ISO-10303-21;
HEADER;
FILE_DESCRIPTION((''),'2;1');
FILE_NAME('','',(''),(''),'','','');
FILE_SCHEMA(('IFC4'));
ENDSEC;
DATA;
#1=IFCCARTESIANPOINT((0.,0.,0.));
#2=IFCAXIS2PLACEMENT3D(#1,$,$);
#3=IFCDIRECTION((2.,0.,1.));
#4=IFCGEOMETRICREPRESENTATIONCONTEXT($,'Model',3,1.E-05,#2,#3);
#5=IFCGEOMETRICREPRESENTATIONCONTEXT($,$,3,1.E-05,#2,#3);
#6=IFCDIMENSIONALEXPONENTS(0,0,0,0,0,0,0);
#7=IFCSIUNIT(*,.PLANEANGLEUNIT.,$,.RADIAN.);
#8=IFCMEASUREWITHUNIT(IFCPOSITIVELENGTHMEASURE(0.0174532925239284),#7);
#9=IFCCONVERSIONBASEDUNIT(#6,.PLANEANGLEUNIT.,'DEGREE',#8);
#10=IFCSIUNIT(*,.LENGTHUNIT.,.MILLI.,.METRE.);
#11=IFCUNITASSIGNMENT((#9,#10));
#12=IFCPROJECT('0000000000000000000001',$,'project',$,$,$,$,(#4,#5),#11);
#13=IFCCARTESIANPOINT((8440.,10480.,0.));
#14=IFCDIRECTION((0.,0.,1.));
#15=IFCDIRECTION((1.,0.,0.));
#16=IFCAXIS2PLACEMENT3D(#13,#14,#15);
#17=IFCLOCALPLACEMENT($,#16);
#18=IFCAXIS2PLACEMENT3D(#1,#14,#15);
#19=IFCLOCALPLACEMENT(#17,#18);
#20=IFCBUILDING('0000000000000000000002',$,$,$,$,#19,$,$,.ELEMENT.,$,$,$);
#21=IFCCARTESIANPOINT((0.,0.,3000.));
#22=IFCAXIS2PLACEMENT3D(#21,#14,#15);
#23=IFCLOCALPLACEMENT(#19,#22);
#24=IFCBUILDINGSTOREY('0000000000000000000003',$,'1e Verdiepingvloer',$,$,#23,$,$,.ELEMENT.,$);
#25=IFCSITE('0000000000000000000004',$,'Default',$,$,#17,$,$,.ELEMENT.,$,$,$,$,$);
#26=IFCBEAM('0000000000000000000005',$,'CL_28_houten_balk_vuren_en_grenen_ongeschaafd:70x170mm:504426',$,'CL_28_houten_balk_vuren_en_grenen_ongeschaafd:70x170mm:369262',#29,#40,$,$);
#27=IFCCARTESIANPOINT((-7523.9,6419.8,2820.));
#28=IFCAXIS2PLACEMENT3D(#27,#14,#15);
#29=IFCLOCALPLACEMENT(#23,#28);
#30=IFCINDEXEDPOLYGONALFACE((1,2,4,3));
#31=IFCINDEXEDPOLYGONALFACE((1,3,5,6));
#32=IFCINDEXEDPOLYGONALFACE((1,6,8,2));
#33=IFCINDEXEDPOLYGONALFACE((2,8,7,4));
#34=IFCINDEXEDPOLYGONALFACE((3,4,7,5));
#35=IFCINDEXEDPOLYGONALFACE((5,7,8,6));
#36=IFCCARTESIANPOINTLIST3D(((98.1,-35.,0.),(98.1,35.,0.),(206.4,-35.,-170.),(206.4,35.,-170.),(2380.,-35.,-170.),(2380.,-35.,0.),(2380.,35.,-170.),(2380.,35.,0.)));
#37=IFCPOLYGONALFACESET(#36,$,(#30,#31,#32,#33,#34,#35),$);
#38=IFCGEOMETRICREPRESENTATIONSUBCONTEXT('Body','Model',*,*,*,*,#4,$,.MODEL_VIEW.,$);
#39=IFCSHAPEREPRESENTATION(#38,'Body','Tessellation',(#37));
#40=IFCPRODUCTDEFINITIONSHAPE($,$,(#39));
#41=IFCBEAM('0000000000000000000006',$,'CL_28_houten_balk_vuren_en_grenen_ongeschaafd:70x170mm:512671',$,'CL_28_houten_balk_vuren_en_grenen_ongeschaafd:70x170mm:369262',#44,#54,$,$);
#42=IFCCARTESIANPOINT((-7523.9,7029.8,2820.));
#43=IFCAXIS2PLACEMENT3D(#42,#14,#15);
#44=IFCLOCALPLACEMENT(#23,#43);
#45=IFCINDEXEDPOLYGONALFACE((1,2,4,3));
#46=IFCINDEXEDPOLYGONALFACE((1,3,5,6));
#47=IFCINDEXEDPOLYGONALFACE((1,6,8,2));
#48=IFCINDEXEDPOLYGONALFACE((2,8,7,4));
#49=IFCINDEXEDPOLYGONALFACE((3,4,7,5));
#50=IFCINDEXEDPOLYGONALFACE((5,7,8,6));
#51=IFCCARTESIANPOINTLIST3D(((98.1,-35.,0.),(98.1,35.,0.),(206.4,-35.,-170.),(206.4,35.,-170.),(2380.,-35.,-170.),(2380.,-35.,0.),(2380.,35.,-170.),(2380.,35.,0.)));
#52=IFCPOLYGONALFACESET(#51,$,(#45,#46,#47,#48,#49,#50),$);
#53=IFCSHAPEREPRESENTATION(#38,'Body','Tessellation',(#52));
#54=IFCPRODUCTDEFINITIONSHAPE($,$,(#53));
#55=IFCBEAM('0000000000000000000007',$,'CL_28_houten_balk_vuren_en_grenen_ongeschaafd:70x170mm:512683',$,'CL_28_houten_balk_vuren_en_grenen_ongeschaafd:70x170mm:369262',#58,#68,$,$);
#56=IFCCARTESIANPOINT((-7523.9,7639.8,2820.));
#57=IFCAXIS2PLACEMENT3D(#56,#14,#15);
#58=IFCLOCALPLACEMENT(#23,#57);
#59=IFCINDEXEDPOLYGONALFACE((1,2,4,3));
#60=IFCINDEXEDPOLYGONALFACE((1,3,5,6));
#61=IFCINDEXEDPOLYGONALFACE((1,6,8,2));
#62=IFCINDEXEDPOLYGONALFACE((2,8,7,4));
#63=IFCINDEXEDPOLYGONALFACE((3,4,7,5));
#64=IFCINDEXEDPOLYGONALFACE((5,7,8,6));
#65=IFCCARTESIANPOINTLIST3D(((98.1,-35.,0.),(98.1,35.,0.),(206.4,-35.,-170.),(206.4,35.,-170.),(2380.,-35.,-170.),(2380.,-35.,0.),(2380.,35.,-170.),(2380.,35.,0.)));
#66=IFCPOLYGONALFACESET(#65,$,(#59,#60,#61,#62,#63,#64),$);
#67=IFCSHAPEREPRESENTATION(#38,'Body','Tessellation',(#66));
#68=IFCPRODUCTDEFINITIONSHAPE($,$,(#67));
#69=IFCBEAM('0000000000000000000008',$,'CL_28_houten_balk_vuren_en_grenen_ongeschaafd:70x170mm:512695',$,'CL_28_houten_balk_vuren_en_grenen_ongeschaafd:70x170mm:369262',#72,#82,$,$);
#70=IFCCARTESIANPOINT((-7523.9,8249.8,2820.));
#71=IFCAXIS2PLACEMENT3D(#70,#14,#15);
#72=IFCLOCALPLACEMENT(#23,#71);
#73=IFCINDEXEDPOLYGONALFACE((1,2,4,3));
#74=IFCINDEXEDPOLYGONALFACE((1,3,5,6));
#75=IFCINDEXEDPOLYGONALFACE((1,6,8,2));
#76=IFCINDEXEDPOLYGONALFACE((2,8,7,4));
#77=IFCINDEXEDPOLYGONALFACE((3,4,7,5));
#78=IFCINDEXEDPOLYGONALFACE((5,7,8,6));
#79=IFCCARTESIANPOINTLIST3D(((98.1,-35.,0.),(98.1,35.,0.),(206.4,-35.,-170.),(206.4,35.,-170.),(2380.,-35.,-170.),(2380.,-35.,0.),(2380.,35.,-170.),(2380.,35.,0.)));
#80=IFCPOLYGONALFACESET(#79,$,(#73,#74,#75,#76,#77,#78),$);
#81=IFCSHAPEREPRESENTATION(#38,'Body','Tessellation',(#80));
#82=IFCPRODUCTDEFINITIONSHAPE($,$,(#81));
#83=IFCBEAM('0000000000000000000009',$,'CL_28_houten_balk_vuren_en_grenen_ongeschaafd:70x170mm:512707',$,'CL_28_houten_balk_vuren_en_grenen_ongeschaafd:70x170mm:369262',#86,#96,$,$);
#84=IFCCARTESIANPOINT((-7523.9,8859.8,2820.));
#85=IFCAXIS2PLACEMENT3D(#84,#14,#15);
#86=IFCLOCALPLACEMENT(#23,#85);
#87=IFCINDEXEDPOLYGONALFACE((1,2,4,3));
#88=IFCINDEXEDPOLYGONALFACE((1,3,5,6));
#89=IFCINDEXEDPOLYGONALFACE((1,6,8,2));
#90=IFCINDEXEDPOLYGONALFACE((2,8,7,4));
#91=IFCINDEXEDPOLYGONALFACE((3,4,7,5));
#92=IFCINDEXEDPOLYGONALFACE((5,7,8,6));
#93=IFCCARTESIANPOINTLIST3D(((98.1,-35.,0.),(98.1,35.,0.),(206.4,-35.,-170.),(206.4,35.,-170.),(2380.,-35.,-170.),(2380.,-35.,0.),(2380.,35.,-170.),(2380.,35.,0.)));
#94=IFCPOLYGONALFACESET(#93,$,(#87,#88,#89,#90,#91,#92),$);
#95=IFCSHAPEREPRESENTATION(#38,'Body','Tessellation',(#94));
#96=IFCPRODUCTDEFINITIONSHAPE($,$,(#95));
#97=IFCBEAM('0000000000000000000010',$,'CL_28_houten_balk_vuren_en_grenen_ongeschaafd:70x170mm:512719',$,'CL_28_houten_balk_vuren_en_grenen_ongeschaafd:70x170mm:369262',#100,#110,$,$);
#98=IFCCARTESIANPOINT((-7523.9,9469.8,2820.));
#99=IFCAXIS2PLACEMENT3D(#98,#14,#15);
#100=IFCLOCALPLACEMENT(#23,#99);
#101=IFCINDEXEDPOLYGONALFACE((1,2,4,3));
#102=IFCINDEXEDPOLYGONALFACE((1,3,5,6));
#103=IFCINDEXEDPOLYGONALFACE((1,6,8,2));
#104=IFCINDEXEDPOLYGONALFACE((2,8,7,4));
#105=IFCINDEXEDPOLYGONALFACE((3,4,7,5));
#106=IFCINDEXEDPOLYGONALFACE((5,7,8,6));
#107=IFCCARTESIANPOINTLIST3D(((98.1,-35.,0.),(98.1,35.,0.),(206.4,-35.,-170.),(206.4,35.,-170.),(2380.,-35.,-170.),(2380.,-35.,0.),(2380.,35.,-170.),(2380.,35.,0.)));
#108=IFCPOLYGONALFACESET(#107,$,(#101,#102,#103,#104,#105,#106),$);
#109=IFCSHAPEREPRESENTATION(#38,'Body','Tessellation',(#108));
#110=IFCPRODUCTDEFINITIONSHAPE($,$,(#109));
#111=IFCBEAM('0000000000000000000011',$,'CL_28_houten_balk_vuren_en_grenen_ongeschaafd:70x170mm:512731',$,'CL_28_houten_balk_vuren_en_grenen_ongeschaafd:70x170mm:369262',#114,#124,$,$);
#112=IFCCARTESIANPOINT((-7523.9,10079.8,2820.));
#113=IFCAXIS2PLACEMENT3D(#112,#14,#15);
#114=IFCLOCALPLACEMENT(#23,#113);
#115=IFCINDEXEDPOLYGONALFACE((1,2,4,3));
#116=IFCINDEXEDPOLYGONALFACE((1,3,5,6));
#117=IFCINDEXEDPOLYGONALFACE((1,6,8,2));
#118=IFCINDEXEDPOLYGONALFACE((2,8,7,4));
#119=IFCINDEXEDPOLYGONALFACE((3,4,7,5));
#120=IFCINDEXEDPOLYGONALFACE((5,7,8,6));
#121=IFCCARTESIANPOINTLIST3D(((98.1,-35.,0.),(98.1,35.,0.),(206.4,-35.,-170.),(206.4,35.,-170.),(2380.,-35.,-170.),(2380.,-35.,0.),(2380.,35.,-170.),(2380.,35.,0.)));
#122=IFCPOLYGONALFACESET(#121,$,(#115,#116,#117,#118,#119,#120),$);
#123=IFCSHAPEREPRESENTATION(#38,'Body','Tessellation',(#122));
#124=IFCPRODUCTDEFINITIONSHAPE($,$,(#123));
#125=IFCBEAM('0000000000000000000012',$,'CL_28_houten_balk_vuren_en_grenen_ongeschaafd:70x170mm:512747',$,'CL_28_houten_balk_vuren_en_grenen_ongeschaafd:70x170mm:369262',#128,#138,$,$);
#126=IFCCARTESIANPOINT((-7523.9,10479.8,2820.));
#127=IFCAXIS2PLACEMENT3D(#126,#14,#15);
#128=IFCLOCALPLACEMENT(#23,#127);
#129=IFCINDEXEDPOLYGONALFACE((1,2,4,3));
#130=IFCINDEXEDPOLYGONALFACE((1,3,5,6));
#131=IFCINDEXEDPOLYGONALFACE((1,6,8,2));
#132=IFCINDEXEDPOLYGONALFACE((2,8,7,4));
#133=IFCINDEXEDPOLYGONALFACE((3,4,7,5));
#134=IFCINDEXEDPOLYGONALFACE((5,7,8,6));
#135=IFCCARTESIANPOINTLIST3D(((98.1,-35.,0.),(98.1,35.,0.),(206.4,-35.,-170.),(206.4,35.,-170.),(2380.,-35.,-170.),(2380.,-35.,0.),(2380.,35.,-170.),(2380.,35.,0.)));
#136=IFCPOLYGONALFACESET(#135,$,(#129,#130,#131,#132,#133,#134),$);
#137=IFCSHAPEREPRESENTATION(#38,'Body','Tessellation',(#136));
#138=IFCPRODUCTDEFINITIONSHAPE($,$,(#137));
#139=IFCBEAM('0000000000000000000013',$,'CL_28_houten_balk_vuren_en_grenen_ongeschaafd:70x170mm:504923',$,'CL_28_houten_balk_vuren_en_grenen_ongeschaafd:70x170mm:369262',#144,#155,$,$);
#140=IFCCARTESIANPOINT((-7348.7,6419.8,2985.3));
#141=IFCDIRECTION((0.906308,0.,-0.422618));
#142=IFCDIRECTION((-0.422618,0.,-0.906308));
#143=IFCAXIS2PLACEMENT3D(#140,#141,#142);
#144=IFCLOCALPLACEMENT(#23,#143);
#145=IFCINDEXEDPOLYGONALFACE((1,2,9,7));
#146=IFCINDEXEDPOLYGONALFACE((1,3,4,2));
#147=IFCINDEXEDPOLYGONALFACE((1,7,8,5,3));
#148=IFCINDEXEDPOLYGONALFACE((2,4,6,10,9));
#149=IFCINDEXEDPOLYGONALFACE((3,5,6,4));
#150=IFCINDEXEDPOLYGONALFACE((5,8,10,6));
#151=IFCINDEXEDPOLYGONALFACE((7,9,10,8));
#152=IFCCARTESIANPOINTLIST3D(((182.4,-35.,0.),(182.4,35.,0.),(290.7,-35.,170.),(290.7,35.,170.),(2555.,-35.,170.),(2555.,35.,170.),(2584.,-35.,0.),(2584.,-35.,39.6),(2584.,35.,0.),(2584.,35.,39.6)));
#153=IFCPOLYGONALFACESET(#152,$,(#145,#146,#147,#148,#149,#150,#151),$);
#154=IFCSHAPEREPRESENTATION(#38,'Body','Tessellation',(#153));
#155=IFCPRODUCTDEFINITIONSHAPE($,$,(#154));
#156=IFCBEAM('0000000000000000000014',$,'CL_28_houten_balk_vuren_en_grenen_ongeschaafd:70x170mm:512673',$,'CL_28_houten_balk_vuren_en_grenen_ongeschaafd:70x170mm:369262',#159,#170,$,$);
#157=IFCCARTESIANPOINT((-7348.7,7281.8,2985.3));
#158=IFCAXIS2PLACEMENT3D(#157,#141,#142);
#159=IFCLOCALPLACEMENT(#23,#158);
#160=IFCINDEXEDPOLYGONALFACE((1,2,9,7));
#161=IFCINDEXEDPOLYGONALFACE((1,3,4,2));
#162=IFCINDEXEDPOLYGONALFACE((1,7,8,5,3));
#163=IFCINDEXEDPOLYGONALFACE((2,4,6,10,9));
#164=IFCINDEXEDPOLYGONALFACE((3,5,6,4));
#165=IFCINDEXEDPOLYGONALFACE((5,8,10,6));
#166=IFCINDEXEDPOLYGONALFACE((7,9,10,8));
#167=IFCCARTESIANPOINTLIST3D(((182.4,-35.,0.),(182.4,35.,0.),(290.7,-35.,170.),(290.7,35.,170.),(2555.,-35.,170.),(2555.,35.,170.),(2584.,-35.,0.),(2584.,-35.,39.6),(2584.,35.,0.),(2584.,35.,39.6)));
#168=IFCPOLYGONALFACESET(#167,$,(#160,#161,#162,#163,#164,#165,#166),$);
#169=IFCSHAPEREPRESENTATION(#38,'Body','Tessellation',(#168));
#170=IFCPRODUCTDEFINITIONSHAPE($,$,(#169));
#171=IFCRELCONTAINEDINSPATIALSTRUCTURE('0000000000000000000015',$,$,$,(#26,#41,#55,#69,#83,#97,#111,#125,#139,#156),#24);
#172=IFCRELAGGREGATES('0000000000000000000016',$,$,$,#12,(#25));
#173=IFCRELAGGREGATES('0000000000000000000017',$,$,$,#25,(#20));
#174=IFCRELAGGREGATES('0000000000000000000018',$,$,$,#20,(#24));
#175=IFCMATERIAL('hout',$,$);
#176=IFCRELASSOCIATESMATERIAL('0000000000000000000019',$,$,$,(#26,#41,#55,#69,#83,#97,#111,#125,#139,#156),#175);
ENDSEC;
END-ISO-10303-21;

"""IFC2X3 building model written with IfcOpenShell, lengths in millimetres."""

from ifc_helpers import new_model, entity, si_unit, converted_unit, direction, frame, frame_2d, origin, origin_with_axes, place, context, subcontext, project, spatial, rectangle, extrude, clip, halfspace, source, transform, mapped, material, element, save


model = new_model("IFC2X3")

# Units and contexts
model_context = context("Model", 3, precision=1e-05, world=origin(), true_north=direction((2.0, 0.0, 1.0)))
context_of_model = context(None, 3, precision=1e-05, world=origin(), true_north=direction((2.0, 0.0, 1.0)))
body_context = subcontext(model_context, "Body", "Model", "MODEL_VIEW")
ifc_project = project(units=[converted_unit("PLANEANGLEUNIT", "DEGREE", entity("IfcPositiveLengthMeasure", 0.0174532925239284), si_unit("PLANEANGLEUNIT", "RADIAN"), dimensions=[0, 0, 0, 0, 0, 0, 0]), si_unit("LENGTHUNIT", "METRE", prefix="MILLI")], contexts=[model_context, context_of_model])

# Site, building, storey
site_placement = place(None, frame((8440.0, 10480.0, 0.0), z_axis=(0.0, 0.0, 1.0), x_axis=(1.0, 0.0, 0.0)))
site = spatial("IfcSite", under=ifc_project, at=site_placement, Name="Default", CompositionType="ELEMENT")
building_placement = place(site_placement, origin_with_axes())
building = spatial("IfcBuilding", under=site, at=building_placement, CompositionType="ELEMENT")
storey_placement = place(building_placement, frame((0.0, 0.0, 3000.0), z_axis=(0.0, 0.0, 1.0), x_axis=(1.0, 0.0, 0.0)))
storey = spatial("IfcBuildingStorey", under=building, at=storey_placement, Name="1e Verdiepingvloer", CompositionType="ELEMENT")

# Beams
ifc_material_1 = material(Name="hout")
shared_shape_1 = source(origin(), body_context, "Body", "Clipping", [
    clip(extrude(rectangle(XDim=170.0, YDim=70.0, at=frame_2d((0.0, 0.0), x_axis=(1.0, 0.0))), frame((98.1, 0.0, -85.0), z_axis=(1.0, 0.0, 0.0), x_axis=(0.0, 0.0, -1.0)), (0.0, 0.0, 1.0), 2281.9), halfspace(frame((206.4, -683.2, -170.0), z_axis=(-0.843391, 0.0, -0.5373), x_axis=(0.5373, 0.0, -0.843391)), False)),
])
for number, where, z_axis, x_axis, name in (
    (1, (-7523.9, 6419.8, 2820.0), (0.0, 0.0, 1.0), (1.0, 0.0, 0.0), "CL_28_houten_balk_vuren_en_grenen_ongeschaafd:70x170mm:504426"),
    (2, (-7523.9, 7029.8, 2820.0), (0.0, 0.0, 1.0), (1.0, 0.0, 0.0), "CL_28_houten_balk_vuren_en_grenen_ongeschaafd:70x170mm:512671"),
    (3, (-7523.9, 7639.8, 2820.0), (0.0, 0.0, 1.0), (1.0, 0.0, 0.0), "CL_28_houten_balk_vuren_en_grenen_ongeschaafd:70x170mm:512683"),
    (4, (-7523.9, 8249.8, 2820.0), (0.0, 0.0, 1.0), (1.0, 0.0, 0.0), "CL_28_houten_balk_vuren_en_grenen_ongeschaafd:70x170mm:512695"),
    (5, (-7523.9, 8859.8, 2820.0), (0.0, 0.0, 1.0), (1.0, 0.0, 0.0), "CL_28_houten_balk_vuren_en_grenen_ongeschaafd:70x170mm:512707"),
    (6, (-7523.9, 9469.8, 2820.0), (0.0, 0.0, 1.0), (1.0, 0.0, 0.0), "CL_28_houten_balk_vuren_en_grenen_ongeschaafd:70x170mm:512719"),
    (7, (-7523.9, 10079.8, 2820.0), (0.0, 0.0, 1.0), (1.0, 0.0, 0.0), "CL_28_houten_balk_vuren_en_grenen_ongeschaafd:70x170mm:512731"),
    (8, (-7523.9, 10479.8, 2820.0), (0.0, 0.0, 1.0), (1.0, 0.0, 0.0), "CL_28_houten_balk_vuren_en_grenen_ongeschaafd:70x170mm:512747"),
):
    element("IfcBeam", number, at=place(storey_placement, frame(where, z_axis=z_axis, x_axis=x_axis)), inside=storey, material=ifc_material_1, Name=name, ObjectType="CL_28_houten_balk_vuren_en_grenen_ongeschaafd:70x170mm:369262", context=body_context, shape_type="MappedRepresentation", body=[
        mapped(shared_shape_1, transform((0.0, 0.0, 0.0))),
    ])
shared_shape_2 = source(origin(), body_context, "Body", "Clipping", [
    clip(clip(extrude(rectangle(XDim=170.0, YDim=70.0, at=frame_2d((0.0, 0.0), x_axis=(0.0, 1.0))), frame((182.4, 0.0, 85.0), z_axis=(1.0, 0.0, 0.0), x_axis=(0.0, 1.0, 0.0)), (0.0, 0.0, 1.0), 2401.5), halfspace(frame((2590.9, -1982.2, 8.5), z_axis=(0.976296, 0.0, 0.21644), x_axis=(-0.21644, 0.0, 0.976296)), False)), halfspace(frame((290.7, -683.2, 170.0), z_axis=(-0.843391, 0.0, 0.5373), x_axis=(0.5373, 0.0, 0.843391)), False)),
])
for number, where, z_axis, x_axis, name in (
    (9, (-7348.7, 6419.8, 2985.3), (0.906308, 0.0, -0.422618), (-0.422618, 0.0, -0.906308), "CL_28_houten_balk_vuren_en_grenen_ongeschaafd:70x170mm:504923"),
    (10, (-7348.7, 7281.8, 2985.3), (0.906308, 0.0, -0.422618), (-0.422618, 0.0, -0.906308), "CL_28_houten_balk_vuren_en_grenen_ongeschaafd:70x170mm:512673"),
):
    element("IfcBeam", number, at=place(storey_placement, frame(where, z_axis=z_axis, x_axis=x_axis)), inside=storey, material=ifc_material_1, Name=name, ObjectType="CL_28_houten_balk_vuren_en_grenen_ongeschaafd:70x170mm:369262", context=body_context, shape_type="MappedRepresentation", body=[
        mapped(shared_shape_2, transform((0.0, 0.0, 0.0))),
    ])

save(model, "model.ifc")
